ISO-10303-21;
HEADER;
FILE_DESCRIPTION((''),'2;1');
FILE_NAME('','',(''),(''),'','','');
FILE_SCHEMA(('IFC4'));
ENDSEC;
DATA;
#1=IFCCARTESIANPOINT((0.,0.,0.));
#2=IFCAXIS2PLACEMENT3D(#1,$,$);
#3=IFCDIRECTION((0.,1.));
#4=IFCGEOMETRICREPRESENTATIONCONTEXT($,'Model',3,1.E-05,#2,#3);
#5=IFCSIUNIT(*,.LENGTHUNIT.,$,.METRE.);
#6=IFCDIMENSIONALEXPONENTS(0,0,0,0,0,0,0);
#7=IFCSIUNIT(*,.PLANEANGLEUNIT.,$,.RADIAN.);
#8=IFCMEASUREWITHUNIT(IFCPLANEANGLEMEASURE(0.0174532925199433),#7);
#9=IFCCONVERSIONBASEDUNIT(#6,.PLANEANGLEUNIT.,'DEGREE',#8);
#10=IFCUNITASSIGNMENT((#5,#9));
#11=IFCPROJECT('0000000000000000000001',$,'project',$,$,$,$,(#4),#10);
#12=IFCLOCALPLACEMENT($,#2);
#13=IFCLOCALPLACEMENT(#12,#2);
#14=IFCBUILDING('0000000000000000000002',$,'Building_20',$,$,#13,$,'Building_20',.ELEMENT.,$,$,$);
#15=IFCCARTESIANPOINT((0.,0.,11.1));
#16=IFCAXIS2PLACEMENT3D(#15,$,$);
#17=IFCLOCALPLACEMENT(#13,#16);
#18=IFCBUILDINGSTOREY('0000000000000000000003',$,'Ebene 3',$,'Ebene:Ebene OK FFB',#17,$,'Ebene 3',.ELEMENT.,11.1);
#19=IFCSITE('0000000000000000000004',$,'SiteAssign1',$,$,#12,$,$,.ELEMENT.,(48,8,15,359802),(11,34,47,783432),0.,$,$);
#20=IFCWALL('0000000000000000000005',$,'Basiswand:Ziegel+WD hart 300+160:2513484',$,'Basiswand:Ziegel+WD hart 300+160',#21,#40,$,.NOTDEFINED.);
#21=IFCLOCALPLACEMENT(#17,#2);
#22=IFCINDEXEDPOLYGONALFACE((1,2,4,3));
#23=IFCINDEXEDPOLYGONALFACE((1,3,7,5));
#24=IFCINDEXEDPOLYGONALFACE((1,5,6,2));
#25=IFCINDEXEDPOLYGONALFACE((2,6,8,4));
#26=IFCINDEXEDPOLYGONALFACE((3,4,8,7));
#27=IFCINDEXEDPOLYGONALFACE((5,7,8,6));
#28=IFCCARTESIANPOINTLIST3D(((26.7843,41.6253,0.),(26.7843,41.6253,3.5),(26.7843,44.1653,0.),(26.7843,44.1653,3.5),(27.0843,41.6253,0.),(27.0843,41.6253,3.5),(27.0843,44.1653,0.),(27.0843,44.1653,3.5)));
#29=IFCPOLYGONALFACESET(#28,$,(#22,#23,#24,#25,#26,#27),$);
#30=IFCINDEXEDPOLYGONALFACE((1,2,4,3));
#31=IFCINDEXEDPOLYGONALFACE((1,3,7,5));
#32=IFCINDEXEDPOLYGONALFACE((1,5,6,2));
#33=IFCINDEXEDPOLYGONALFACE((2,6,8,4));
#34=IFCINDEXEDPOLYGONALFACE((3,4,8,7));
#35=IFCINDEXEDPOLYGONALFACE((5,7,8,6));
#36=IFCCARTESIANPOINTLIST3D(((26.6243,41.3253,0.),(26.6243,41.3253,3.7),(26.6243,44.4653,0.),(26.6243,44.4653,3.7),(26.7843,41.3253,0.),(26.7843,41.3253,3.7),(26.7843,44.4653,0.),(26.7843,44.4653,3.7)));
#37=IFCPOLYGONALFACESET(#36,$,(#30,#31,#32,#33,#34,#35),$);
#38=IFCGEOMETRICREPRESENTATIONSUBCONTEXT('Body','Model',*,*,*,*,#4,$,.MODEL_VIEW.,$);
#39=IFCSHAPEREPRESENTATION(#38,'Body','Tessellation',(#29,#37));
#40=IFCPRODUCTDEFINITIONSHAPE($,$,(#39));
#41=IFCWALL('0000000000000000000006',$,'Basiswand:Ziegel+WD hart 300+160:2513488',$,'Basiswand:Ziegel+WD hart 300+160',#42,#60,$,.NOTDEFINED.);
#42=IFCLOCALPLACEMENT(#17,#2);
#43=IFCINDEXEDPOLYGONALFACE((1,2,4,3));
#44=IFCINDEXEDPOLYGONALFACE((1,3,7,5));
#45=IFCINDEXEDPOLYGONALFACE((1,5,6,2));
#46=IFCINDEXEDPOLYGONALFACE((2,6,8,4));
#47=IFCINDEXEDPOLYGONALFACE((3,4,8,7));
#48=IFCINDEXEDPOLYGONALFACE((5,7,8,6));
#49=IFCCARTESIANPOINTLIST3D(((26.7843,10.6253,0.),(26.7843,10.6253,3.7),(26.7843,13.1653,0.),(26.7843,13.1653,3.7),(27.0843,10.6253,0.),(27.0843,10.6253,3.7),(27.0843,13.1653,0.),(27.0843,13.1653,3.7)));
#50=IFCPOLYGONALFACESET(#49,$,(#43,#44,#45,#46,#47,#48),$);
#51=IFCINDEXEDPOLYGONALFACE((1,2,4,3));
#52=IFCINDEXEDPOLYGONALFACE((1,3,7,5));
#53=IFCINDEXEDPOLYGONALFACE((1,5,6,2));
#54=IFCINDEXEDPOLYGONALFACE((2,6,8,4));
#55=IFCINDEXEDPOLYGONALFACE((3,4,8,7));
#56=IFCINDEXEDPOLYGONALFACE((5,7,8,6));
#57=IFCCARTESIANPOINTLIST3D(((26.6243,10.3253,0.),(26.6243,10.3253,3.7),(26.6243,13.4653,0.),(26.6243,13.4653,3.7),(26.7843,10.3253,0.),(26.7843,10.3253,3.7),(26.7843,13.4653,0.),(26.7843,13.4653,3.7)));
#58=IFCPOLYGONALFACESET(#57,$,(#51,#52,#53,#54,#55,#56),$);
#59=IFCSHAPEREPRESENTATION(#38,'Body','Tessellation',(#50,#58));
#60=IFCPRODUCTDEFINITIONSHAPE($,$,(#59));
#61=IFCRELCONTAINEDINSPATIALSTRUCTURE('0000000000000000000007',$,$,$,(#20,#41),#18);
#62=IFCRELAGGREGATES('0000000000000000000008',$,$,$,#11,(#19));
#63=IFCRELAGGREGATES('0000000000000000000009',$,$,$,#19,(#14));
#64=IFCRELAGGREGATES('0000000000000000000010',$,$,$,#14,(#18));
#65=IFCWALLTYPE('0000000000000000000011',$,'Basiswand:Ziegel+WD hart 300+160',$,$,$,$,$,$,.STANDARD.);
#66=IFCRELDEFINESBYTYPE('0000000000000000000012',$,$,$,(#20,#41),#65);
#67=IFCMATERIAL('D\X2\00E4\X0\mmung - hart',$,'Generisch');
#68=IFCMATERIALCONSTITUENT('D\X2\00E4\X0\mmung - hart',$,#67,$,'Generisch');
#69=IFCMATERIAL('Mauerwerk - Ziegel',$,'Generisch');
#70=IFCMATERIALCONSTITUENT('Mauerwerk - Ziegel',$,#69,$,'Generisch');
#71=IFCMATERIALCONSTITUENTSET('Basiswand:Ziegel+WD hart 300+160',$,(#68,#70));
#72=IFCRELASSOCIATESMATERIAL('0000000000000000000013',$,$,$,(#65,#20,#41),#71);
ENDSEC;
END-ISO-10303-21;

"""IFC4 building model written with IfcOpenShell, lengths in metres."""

from ifc_helpers import new_model, entity, si_unit, converted_unit, direction, frame, origin, place, context, subcontext, project, spatial, indexed_curve, outline, extrude, material, constituent, constituent_set, type_object, element, save


model = new_model("IFC4")

# Units and contexts
model_context = context("Model", 3, precision=1e-05, world=origin(), true_north=direction((0.0, 1.0)))
body_context = subcontext(model_context, "Body", "Model", "MODEL_VIEW")
ifc_project = project(units=[si_unit("LENGTHUNIT", "METRE"), converted_unit("PLANEANGLEUNIT", "DEGREE", entity("IfcPlaneAngleMeasure", 0.0174532925199433), si_unit("PLANEANGLEUNIT", "RADIAN"), dimensions=[0, 0, 0, 0, 0, 0, 0])], contexts=[model_context])

# Site, building, storey
site_placement = place(None, origin())
site = spatial("IfcSite", under=ifc_project, at=site_placement, Name="SiteAssign1", CompositionType="ELEMENT", RefLatitude=(48, 8, 15, 359802), RefLongitude=(11, 34, 47, 783432), RefElevation=0.0)
building_placement = place(site_placement, origin())
building = spatial("IfcBuilding", under=site, at=building_placement, Name="Building_20", LongName="Building_20", CompositionType="ELEMENT")
storey_placement = place(building_placement, frame((0.0, 0.0, 11.1)))
storey = spatial("IfcBuildingStorey", under=building, at=storey_placement, Name="Ebene 3", ObjectType="Ebene:Ebene OK FFB", LongName="Ebene 3", CompositionType="ELEMENT", Elevation=11.1)

# Walls
ifc_material_1 = material(Name="Dämmung - hart", Category="Generisch")
ifc_constituent_1 = constituent(ifc_material_1, Name="Dämmung - hart", Category="Generisch")
ifc_material_2 = material(Name="Mauerwerk - Ziegel", Category="Generisch")
ifc_constituent_2 = constituent(ifc_material_2, Name="Mauerwerk - Ziegel", Category="Generisch")
ifc_constituent_set = constituent_set(constituents=[ifc_constituent_1, ifc_constituent_2], Name="Basiswand:Ziegel+WD hart 300+160")
wall_type = type_object("IfcWallType", Name="Basiswand:Ziegel+WD hart 300+160", PredefinedType="STANDARD", material=ifc_constituent_set)
wall_1_placement = place(storey_placement, frame((26.8543, 41.6253, 0.0), z_axis=(0.0, 0.0, 1.0), x_axis=(0.0, 1.0, 0.0)))
element("IfcWall", 1, at=wall_1_placement, inside=storey, type_object=wall_type, material=ifc_constituent_set, Name="Basiswand:Ziegel+WD hart 300+160:2513484", ObjectType="Basiswand:Ziegel+WD hart 300+160", PredefinedType="NOTDEFINED", context=body_context, shape_type="SweptSolid", body=[
    extrude(outline(indexed_curve([(-1.75, -1.27), (1.75, -1.27), (1.75, 1.27), (-1.75, 1.27), (-1.75, -1.27)], self_intersect=False)), frame((1.27, 0.07, 1.75), z_axis=(0.0, -1.0, 0.0), x_axis=(0.0, 0.0, 1.0)), (0.0, 0.0, 1.0), 0.3),
    extrude(outline(indexed_curve([(-0.08, -1.57), (0.08, -1.57), (0.08, 1.57), (-0.08, 1.57), (-0.08, -1.57)], self_intersect=False)), frame((1.27, 0.15, 0.0), z_axis=(0.0, 0.0, 1.0), x_axis=(0.0, -1.0, 0.0)), (0.0, 0.0, 1.0), 3.7),
])
wall_2_placement = place(storey_placement, frame((26.8543, 10.6253, 0.0), z_axis=(0.0, 0.0, 1.0), x_axis=(0.0, 1.0, 0.0)))
element("IfcWall", 2, at=wall_2_placement, inside=storey, type_object=wall_type, material=ifc_constituent_set, Name="Basiswand:Ziegel+WD hart 300+160:2513488", ObjectType="Basiswand:Ziegel+WD hart 300+160", PredefinedType="NOTDEFINED", context=body_context, shape_type="SweptSolid", body=[
    extrude(outline(indexed_curve([(-0.15, -1.27), (0.15, -1.27), (0.15, 1.27), (-0.15, 1.27), (-0.15, -1.27)], self_intersect=False)), frame((1.27, -0.08, 0.0), z_axis=(0.0, 0.0, 1.0), x_axis=(0.0, 1.0, 0.0)), (0.0, 0.0, 1.0), 3.7),
    extrude(outline(indexed_curve([(-0.08, -1.57), (0.08, -1.57), (0.08, 1.57), (-0.08, 1.57), (-0.08, -1.57)], self_intersect=False)), frame((1.27, 0.15, 0.0), z_axis=(0.0, 0.0, 1.0), x_axis=(0.0, -1.0, 0.0)), (0.0, 0.0, 1.0), 3.7),
])

save(model, "model.ifc")
